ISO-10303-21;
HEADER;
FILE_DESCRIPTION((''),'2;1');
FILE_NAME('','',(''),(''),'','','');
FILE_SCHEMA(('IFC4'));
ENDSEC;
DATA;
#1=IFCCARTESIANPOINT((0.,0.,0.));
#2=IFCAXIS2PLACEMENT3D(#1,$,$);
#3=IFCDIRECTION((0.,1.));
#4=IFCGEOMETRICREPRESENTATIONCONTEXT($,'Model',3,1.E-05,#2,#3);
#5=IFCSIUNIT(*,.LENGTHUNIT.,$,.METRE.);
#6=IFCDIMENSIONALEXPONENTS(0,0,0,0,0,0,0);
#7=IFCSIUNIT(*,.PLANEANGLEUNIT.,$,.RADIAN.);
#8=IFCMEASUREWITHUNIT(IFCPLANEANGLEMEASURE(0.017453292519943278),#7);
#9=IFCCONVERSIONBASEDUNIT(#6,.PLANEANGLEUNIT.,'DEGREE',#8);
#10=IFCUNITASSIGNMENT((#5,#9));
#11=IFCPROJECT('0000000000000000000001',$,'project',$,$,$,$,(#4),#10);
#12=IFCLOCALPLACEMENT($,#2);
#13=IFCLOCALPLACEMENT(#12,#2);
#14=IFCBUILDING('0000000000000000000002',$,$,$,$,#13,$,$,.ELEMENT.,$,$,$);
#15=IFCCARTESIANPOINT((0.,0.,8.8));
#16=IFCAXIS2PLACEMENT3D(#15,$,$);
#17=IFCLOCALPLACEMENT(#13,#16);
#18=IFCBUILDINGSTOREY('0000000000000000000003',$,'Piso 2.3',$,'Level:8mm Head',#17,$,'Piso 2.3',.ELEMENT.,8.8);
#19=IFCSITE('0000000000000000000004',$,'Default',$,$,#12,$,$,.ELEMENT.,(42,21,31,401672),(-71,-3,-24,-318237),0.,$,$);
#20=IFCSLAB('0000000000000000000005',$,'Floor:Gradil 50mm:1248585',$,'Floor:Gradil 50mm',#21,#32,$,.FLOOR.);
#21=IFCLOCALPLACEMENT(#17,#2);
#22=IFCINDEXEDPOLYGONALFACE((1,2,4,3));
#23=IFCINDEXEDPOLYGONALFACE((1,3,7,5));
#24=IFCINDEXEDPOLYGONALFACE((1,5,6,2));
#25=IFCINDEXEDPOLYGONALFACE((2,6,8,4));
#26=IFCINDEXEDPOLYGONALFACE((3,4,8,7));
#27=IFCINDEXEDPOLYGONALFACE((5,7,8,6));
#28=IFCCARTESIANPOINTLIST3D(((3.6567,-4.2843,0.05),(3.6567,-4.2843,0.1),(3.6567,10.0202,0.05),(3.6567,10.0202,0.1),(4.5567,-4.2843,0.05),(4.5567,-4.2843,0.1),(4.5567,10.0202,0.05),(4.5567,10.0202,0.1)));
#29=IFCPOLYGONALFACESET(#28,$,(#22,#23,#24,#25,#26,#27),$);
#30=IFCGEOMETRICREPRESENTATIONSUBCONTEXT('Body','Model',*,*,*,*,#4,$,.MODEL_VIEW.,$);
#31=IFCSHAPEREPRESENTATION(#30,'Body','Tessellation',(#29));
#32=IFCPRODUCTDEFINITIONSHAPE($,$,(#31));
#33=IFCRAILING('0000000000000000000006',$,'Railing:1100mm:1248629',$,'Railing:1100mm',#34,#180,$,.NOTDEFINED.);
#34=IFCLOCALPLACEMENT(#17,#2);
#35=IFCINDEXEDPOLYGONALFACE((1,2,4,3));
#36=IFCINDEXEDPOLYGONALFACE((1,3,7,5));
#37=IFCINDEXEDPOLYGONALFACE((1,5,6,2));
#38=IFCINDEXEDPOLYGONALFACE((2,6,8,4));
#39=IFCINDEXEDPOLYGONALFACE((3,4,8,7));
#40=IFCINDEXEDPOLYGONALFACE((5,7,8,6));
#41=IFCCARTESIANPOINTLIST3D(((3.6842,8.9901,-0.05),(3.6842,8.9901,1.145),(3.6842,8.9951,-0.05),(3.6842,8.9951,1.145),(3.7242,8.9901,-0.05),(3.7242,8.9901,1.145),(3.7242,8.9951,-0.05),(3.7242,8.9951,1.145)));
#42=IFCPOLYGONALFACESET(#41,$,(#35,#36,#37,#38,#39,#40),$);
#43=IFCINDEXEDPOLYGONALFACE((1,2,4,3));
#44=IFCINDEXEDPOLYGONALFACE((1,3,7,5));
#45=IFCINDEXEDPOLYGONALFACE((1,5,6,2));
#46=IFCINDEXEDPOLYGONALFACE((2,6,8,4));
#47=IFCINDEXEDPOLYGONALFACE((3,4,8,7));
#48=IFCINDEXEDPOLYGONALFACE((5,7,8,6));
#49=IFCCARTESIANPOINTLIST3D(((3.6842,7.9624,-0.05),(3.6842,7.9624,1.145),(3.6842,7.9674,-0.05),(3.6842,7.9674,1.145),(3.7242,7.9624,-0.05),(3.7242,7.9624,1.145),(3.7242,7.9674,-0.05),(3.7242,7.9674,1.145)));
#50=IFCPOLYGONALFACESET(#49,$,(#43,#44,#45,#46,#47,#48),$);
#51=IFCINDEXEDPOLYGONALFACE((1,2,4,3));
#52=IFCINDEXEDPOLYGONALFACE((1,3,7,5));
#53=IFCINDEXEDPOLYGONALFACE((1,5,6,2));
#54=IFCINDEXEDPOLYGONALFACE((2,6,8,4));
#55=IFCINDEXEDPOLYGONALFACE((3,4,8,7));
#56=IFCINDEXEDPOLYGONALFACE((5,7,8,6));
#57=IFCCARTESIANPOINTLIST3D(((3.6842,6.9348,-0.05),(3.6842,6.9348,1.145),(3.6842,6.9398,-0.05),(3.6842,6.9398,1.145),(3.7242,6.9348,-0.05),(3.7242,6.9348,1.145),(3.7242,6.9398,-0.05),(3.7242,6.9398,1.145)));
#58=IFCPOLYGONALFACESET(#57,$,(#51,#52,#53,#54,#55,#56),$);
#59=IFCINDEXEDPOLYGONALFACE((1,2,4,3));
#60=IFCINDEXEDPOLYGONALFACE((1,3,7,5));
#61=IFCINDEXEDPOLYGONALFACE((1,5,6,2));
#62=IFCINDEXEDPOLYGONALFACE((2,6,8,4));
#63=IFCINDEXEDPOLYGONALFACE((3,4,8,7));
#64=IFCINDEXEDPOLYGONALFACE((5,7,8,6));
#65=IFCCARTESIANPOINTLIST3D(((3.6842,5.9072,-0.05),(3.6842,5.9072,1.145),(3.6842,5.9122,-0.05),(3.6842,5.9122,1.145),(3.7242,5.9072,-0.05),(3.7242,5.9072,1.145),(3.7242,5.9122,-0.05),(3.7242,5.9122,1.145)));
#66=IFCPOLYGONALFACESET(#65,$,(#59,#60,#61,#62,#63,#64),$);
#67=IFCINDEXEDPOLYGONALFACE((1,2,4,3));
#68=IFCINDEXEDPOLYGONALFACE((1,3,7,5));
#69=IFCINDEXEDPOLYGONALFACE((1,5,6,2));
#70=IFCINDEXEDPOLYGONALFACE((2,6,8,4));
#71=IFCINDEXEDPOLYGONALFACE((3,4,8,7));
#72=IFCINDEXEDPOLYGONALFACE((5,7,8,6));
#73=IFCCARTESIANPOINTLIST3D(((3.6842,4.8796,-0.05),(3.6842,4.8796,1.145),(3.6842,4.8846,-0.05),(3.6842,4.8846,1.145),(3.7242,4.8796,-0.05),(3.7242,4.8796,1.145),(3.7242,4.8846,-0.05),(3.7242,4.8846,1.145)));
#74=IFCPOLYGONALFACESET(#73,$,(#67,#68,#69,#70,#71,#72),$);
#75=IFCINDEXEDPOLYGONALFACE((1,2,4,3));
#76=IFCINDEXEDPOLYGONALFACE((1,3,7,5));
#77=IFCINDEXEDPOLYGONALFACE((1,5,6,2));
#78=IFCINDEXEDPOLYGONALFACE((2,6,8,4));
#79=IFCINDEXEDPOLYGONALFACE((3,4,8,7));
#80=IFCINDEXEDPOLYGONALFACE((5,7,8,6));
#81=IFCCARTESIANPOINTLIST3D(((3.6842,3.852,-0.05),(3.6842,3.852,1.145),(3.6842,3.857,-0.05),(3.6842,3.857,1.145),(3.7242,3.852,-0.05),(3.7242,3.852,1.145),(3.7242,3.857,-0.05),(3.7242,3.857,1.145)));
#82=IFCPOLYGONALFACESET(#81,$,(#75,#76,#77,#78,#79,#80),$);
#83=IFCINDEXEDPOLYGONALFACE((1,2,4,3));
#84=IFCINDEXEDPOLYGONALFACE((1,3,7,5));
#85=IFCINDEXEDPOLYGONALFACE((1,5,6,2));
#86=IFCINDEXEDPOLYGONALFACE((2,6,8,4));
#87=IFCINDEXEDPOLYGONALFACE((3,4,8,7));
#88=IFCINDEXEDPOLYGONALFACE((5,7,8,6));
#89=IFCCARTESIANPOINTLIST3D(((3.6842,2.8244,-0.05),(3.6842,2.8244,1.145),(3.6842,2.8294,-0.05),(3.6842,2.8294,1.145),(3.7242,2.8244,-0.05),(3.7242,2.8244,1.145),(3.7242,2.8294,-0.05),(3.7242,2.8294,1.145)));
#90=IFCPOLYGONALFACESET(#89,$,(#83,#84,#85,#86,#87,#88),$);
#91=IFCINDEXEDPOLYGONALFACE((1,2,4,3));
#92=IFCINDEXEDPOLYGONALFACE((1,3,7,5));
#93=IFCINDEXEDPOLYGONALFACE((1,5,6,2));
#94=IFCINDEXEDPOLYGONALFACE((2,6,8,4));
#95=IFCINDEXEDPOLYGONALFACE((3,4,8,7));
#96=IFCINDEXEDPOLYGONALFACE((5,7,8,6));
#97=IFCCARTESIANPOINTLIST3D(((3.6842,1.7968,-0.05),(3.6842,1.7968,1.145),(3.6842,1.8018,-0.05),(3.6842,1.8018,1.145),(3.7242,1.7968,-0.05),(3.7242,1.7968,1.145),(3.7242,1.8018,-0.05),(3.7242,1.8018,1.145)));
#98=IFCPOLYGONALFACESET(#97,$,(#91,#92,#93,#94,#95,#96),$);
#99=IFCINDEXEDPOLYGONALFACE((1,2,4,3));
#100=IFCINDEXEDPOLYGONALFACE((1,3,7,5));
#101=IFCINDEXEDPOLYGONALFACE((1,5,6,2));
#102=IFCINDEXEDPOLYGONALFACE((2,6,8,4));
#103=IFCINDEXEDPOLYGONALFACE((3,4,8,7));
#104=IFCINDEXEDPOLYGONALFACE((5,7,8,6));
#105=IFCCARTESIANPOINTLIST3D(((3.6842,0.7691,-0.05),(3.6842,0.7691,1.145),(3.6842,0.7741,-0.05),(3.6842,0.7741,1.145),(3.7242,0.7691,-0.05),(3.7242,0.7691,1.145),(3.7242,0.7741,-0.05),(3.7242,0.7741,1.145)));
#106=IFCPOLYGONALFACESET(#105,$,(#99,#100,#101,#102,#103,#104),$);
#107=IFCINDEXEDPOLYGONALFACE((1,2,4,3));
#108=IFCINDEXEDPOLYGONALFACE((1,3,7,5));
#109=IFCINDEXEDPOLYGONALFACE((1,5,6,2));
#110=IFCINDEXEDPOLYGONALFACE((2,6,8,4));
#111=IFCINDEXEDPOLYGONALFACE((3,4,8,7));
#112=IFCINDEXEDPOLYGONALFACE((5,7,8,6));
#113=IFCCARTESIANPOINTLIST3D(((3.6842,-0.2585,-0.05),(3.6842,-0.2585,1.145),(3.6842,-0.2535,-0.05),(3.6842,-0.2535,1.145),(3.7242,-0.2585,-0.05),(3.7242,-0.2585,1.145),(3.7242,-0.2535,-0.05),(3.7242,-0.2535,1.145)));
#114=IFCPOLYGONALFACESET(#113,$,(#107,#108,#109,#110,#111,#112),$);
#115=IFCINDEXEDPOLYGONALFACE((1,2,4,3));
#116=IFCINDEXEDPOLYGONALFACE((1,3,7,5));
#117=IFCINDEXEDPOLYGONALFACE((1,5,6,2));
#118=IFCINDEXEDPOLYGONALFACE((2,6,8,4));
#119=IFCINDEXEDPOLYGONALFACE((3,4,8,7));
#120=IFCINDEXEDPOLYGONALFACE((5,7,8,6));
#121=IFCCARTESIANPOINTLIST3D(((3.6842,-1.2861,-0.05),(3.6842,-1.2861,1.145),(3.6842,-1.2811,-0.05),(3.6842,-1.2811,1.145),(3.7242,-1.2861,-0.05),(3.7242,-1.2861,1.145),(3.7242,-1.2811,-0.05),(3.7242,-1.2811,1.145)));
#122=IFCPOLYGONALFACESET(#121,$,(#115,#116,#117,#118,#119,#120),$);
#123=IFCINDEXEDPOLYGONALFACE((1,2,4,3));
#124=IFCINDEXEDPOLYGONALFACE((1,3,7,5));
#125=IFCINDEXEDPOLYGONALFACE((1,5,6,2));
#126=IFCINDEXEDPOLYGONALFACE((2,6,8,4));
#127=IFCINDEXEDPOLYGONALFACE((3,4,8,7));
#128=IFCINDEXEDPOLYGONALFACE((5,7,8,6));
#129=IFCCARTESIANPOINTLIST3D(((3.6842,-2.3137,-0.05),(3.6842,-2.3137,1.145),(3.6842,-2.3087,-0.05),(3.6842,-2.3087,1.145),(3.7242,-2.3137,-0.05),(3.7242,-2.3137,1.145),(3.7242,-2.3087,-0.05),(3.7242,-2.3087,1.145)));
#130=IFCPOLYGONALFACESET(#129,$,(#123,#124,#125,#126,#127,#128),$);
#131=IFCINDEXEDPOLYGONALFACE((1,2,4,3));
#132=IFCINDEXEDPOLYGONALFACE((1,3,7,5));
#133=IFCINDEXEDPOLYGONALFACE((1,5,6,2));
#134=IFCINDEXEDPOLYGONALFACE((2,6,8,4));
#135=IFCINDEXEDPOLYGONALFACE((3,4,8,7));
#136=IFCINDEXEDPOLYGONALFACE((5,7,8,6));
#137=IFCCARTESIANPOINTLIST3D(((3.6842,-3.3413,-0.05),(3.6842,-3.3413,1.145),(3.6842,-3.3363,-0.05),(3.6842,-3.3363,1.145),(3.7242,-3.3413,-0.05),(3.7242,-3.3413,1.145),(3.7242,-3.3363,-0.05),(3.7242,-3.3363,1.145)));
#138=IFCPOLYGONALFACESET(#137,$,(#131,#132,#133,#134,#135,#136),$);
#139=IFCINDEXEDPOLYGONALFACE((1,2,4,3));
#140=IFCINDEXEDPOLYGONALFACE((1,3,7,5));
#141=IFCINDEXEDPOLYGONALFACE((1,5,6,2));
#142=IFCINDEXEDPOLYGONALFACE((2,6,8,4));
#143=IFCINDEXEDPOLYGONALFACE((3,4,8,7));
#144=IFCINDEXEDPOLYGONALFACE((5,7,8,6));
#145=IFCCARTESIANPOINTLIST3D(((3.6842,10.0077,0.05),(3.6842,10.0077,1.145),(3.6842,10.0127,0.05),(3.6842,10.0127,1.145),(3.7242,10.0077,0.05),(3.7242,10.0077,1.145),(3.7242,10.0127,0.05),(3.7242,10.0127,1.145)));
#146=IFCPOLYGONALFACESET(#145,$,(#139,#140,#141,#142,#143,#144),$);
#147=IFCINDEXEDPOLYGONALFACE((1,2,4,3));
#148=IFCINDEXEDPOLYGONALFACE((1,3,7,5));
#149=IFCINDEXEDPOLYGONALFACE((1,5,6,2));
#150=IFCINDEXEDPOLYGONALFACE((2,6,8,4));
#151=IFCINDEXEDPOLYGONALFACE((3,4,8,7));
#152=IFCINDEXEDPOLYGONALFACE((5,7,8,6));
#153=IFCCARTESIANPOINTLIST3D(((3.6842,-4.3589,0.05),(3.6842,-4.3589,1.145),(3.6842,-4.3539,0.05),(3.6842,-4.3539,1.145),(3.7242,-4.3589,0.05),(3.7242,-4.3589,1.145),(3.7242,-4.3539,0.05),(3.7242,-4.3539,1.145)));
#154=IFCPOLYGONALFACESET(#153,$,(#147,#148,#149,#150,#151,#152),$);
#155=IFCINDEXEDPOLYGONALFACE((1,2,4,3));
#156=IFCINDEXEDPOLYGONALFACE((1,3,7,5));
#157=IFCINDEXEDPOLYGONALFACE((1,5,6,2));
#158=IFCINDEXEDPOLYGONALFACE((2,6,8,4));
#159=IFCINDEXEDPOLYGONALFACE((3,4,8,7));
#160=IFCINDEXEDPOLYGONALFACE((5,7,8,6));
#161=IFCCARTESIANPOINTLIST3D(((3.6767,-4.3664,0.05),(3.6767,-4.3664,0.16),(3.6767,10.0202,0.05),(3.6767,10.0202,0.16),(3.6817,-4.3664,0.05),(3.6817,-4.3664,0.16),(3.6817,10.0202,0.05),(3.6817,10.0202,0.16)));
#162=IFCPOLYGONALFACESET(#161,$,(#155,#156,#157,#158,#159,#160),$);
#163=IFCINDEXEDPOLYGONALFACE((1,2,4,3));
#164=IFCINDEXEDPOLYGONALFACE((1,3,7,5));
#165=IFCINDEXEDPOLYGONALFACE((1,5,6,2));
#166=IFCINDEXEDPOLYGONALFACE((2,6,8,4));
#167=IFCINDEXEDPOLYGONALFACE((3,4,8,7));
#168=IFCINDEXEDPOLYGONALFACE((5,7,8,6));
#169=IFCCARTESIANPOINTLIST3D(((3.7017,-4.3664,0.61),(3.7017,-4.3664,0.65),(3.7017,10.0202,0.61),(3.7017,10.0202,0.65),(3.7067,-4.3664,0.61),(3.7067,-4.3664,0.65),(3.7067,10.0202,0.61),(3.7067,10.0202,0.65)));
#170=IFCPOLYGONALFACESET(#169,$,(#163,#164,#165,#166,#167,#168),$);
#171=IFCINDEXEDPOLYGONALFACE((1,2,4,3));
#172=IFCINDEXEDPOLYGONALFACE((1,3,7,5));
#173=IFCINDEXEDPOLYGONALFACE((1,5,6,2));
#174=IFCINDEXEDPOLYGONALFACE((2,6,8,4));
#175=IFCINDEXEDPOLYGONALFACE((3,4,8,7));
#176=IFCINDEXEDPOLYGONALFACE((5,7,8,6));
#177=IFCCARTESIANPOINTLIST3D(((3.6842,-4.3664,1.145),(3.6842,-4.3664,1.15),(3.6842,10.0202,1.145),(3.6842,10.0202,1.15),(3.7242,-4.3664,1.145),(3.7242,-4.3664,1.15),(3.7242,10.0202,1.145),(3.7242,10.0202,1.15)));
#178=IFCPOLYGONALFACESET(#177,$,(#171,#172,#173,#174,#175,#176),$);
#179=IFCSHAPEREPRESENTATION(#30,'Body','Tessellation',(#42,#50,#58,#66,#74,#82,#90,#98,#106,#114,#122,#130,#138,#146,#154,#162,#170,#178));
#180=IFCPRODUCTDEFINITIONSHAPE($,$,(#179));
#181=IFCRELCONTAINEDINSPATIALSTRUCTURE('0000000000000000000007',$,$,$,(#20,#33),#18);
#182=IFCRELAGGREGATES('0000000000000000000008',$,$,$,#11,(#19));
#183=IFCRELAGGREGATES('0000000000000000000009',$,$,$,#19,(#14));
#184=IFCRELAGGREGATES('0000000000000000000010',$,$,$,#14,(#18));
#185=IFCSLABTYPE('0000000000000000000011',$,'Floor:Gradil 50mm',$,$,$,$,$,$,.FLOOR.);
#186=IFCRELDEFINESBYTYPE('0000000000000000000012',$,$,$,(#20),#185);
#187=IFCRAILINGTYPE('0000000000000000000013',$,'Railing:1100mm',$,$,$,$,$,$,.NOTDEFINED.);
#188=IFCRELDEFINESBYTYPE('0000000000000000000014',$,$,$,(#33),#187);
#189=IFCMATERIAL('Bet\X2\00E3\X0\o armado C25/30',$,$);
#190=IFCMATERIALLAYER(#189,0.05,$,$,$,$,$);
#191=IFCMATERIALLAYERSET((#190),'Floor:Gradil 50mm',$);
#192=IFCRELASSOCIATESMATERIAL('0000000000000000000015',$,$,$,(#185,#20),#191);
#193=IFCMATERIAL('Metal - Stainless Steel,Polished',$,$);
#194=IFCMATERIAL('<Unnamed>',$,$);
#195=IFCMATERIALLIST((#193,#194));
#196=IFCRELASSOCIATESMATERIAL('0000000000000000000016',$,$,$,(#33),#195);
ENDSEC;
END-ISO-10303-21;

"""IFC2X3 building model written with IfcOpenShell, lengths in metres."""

from ifc_helpers import new_model, entity, si_unit, converted_unit, direction, frame, frame_2d, origin, place, context, subcontext, project, spatial, rectangle, extrude, material, material_list, layer, layer_set, layer_usage, type_object, element, save


model = new_model("IFC2X3")

# Units and contexts
model_context = context("Model", 3, precision=1e-05, world=origin(), true_north=direction((0.0, 1.0)))
body_context = subcontext(model_context, "Body", "Model", "MODEL_VIEW")
ifc_project = project(units=[si_unit("LENGTHUNIT", "METRE"), converted_unit("PLANEANGLEUNIT", "DEGREE", entity("IfcPlaneAngleMeasure", 0.017453292519943278), si_unit("PLANEANGLEUNIT", "RADIAN"), dimensions=[0, 0, 0, 0, 0, 0, 0])], contexts=[model_context])

# Site, building, storey
site_placement = place(None, origin())
site = spatial("IfcSite", under=ifc_project, at=site_placement, Name="Default", CompositionType="ELEMENT", RefLatitude=(42, 21, 31, 401672), RefLongitude=(-71, -3, -24, -318237), RefElevation=0.0)
building_placement = place(site_placement, origin())
building = spatial("IfcBuilding", under=site, at=building_placement, CompositionType="ELEMENT")
storey_placement = place(building_placement, frame((0.0, 0.0, 8.8)))
storey = spatial("IfcBuildingStorey", under=building, at=storey_placement, Name="Piso 2.3", ObjectType="Level:8mm Head", LongName="Piso 2.3", CompositionType="ELEMENT", Elevation=8.8)

# Slab
ifc_material_1 = material(Name="Betão armado C25/30")
ifc_layer = layer(ifc_material_1, 0.05)
ifc_layer_set = layer_set([ifc_layer], Name="Floor:Gradil 50mm")
ifc_layer_usage = layer_usage(ifc_layer_set, "AXIS3", "POSITIVE", 0.0)
slab_type = type_object("IfcSlabType", Name="Floor:Gradil 50mm", PredefinedType="FLOOR", material=ifc_layer_set)
slab_placement = place(storey_placement, origin())
element("IfcSlab", 1, at=slab_placement, inside=storey, type_object=slab_type, material=ifc_layer_usage, Name="Floor:Gradil 50mm:1248585", ObjectType="Floor:Gradil 50mm", PredefinedType="FLOOR", context=body_context, shape_type="SweptSolid", body=[
    extrude(rectangle(XDim=14.3044, YDim=0.9, at=frame_2d((0.0, 0.0), x_axis=(1.0, 0.0))), frame((4.1067, 2.8679, 0.1), z_axis=(0.0, 0.0, -1.0), x_axis=(0.0, 1.0, 0.0)), (0.0, 0.0, 1.0), 0.05),
])

# Railing
ifc_material_2 = material(Name="Metal - Stainless Steel,Polished")
ifc_material_3 = material(Name="<Unnamed>")
ifc_material_list = material_list([ifc_material_2, ifc_material_3])
railing_type = type_object("IfcRailingType", Name="Railing:1100mm", PredefinedType="NOTDEFINED")
railing_1_placement = place(storey_placement, origin())
element("IfcRailing", 2, at=railing_1_placement, inside=storey, type_object=railing_type, material=ifc_material_list, Name="Railing:1100mm:1248629", ObjectType="Railing:1100mm", PredefinedType="NOTDEFINED", context=body_context, shape_type="SweptSolid", body=[
    extrude(rectangle(XDim=0.04, YDim=0.005, at=frame_2d((0.0, 0.0), x_axis=(1.0, 0.0))), frame((3.7042, 8.9926, -0.05)), (0.0, 0.0, 1.0), 1.195),
    extrude(rectangle(XDim=0.04, YDim=0.005, at=frame_2d((0.0, 0.0), x_axis=(1.0, 0.0))), frame((3.7042, 7.9649, -0.05)), (0.0, 0.0, 1.0), 1.195),
    extrude(rectangle(XDim=0.04, YDim=0.005, at=frame_2d((0.0, 0.0), x_axis=(1.0, 0.0))), frame((3.7042, 6.9373, -0.05)), (0.0, 0.0, 1.0), 1.195),
    extrude(rectangle(XDim=0.04, YDim=0.005, at=frame_2d((0.0, 0.0), x_axis=(1.0, 0.0))), frame((3.7042, 5.9097, -0.05)), (0.0, 0.0, 1.0), 1.195),
    extrude(rectangle(XDim=0.04, YDim=0.005, at=frame_2d((0.0, 0.0), x_axis=(1.0, 0.0))), frame((3.7042, 4.8821, -0.05)), (0.0, 0.0, 1.0), 1.195),
    extrude(rectangle(XDim=0.04, YDim=0.005, at=frame_2d((0.0, 0.0), x_axis=(1.0, 0.0))), frame((3.7042, 3.8545, -0.05)), (0.0, 0.0, 1.0), 1.195),
    extrude(rectangle(XDim=0.04, YDim=0.005, at=frame_2d((0.0, 0.0), x_axis=(1.0, 0.0))), frame((3.7042, 2.8269, -0.05)), (0.0, 0.0, 1.0), 1.195),
    extrude(rectangle(XDim=0.04, YDim=0.005, at=frame_2d((0.0, 0.0), x_axis=(1.0, 0.0))), frame((3.7042, 1.7993, -0.05)), (0.0, 0.0, 1.0), 1.195),
    extrude(rectangle(XDim=0.04, YDim=0.005, at=frame_2d((0.0, 0.0), x_axis=(1.0, 0.0))), frame((3.7042, 0.7716, -0.05)), (0.0, 0.0, 1.0), 1.195),
    extrude(rectangle(XDim=0.04, YDim=0.005, at=frame_2d((0.0, 0.0), x_axis=(1.0, 0.0))), frame((3.7042, -0.256, -0.05)), (0.0, 0.0, 1.0), 1.195),
    extrude(rectangle(XDim=0.04, YDim=0.005, at=frame_2d((0.0, 0.0), x_axis=(1.0, 0.0))), frame((3.7042, -1.2836, -0.05)), (0.0, 0.0, 1.0), 1.195),
    extrude(rectangle(XDim=0.04, YDim=0.005, at=frame_2d((0.0, 0.0), x_axis=(1.0, 0.0))), frame((3.7042, -2.3112, -0.05)), (0.0, 0.0, 1.0), 1.195),
    extrude(rectangle(XDim=0.04, YDim=0.005, at=frame_2d((0.0, 0.0), x_axis=(1.0, 0.0))), frame((3.7042, -3.3388, -0.05)), (0.0, 0.0, 1.0), 1.195),
    extrude(rectangle(XDim=0.04, YDim=0.005, at=frame_2d((0.0, 0.0), x_axis=(1.0, 0.0))), frame((3.7042, 10.0102, 0.05)), (0.0, 0.0, 1.0), 1.095),
    extrude(rectangle(XDim=0.04, YDim=0.005, at=frame_2d((0.0, 0.0), x_axis=(1.0, 0.0))), frame((3.7042, -4.3564, 0.05)), (0.0, 0.0, 1.0), 1.095),
    extrude(rectangle(XDim=14.3866, YDim=0.005, at=frame_2d((0.0, 0.0), x_axis=(1.0, 0.0))), frame((3.6792, 2.8269, 0.05), z_axis=(0.0, 0.0, 1.0), x_axis=(0.0, 1.0, 0.0)), (0.0, 0.0, 1.0), 0.11),
    extrude(rectangle(XDim=14.3866, YDim=0.005, at=frame_2d((0.0, 0.0), x_axis=(1.0, 0.0))), frame((3.7042, 2.8269, 0.61), z_axis=(0.0, 0.0, 1.0), x_axis=(0.0, 1.0, 0.0)), (0.0, 0.0, 1.0), 0.04),
    extrude(rectangle(XDim=14.3866, YDim=0.04, at=frame_2d((0.0, 0.0), x_axis=(1.0, 0.0))), frame((3.7042, 2.8269, 1.145), z_axis=(0.0, 0.0, 1.0), x_axis=(0.0, 1.0, 0.0)), (0.0, 0.0, 1.0), 0.005),
])

save(model, "model.ifc")
